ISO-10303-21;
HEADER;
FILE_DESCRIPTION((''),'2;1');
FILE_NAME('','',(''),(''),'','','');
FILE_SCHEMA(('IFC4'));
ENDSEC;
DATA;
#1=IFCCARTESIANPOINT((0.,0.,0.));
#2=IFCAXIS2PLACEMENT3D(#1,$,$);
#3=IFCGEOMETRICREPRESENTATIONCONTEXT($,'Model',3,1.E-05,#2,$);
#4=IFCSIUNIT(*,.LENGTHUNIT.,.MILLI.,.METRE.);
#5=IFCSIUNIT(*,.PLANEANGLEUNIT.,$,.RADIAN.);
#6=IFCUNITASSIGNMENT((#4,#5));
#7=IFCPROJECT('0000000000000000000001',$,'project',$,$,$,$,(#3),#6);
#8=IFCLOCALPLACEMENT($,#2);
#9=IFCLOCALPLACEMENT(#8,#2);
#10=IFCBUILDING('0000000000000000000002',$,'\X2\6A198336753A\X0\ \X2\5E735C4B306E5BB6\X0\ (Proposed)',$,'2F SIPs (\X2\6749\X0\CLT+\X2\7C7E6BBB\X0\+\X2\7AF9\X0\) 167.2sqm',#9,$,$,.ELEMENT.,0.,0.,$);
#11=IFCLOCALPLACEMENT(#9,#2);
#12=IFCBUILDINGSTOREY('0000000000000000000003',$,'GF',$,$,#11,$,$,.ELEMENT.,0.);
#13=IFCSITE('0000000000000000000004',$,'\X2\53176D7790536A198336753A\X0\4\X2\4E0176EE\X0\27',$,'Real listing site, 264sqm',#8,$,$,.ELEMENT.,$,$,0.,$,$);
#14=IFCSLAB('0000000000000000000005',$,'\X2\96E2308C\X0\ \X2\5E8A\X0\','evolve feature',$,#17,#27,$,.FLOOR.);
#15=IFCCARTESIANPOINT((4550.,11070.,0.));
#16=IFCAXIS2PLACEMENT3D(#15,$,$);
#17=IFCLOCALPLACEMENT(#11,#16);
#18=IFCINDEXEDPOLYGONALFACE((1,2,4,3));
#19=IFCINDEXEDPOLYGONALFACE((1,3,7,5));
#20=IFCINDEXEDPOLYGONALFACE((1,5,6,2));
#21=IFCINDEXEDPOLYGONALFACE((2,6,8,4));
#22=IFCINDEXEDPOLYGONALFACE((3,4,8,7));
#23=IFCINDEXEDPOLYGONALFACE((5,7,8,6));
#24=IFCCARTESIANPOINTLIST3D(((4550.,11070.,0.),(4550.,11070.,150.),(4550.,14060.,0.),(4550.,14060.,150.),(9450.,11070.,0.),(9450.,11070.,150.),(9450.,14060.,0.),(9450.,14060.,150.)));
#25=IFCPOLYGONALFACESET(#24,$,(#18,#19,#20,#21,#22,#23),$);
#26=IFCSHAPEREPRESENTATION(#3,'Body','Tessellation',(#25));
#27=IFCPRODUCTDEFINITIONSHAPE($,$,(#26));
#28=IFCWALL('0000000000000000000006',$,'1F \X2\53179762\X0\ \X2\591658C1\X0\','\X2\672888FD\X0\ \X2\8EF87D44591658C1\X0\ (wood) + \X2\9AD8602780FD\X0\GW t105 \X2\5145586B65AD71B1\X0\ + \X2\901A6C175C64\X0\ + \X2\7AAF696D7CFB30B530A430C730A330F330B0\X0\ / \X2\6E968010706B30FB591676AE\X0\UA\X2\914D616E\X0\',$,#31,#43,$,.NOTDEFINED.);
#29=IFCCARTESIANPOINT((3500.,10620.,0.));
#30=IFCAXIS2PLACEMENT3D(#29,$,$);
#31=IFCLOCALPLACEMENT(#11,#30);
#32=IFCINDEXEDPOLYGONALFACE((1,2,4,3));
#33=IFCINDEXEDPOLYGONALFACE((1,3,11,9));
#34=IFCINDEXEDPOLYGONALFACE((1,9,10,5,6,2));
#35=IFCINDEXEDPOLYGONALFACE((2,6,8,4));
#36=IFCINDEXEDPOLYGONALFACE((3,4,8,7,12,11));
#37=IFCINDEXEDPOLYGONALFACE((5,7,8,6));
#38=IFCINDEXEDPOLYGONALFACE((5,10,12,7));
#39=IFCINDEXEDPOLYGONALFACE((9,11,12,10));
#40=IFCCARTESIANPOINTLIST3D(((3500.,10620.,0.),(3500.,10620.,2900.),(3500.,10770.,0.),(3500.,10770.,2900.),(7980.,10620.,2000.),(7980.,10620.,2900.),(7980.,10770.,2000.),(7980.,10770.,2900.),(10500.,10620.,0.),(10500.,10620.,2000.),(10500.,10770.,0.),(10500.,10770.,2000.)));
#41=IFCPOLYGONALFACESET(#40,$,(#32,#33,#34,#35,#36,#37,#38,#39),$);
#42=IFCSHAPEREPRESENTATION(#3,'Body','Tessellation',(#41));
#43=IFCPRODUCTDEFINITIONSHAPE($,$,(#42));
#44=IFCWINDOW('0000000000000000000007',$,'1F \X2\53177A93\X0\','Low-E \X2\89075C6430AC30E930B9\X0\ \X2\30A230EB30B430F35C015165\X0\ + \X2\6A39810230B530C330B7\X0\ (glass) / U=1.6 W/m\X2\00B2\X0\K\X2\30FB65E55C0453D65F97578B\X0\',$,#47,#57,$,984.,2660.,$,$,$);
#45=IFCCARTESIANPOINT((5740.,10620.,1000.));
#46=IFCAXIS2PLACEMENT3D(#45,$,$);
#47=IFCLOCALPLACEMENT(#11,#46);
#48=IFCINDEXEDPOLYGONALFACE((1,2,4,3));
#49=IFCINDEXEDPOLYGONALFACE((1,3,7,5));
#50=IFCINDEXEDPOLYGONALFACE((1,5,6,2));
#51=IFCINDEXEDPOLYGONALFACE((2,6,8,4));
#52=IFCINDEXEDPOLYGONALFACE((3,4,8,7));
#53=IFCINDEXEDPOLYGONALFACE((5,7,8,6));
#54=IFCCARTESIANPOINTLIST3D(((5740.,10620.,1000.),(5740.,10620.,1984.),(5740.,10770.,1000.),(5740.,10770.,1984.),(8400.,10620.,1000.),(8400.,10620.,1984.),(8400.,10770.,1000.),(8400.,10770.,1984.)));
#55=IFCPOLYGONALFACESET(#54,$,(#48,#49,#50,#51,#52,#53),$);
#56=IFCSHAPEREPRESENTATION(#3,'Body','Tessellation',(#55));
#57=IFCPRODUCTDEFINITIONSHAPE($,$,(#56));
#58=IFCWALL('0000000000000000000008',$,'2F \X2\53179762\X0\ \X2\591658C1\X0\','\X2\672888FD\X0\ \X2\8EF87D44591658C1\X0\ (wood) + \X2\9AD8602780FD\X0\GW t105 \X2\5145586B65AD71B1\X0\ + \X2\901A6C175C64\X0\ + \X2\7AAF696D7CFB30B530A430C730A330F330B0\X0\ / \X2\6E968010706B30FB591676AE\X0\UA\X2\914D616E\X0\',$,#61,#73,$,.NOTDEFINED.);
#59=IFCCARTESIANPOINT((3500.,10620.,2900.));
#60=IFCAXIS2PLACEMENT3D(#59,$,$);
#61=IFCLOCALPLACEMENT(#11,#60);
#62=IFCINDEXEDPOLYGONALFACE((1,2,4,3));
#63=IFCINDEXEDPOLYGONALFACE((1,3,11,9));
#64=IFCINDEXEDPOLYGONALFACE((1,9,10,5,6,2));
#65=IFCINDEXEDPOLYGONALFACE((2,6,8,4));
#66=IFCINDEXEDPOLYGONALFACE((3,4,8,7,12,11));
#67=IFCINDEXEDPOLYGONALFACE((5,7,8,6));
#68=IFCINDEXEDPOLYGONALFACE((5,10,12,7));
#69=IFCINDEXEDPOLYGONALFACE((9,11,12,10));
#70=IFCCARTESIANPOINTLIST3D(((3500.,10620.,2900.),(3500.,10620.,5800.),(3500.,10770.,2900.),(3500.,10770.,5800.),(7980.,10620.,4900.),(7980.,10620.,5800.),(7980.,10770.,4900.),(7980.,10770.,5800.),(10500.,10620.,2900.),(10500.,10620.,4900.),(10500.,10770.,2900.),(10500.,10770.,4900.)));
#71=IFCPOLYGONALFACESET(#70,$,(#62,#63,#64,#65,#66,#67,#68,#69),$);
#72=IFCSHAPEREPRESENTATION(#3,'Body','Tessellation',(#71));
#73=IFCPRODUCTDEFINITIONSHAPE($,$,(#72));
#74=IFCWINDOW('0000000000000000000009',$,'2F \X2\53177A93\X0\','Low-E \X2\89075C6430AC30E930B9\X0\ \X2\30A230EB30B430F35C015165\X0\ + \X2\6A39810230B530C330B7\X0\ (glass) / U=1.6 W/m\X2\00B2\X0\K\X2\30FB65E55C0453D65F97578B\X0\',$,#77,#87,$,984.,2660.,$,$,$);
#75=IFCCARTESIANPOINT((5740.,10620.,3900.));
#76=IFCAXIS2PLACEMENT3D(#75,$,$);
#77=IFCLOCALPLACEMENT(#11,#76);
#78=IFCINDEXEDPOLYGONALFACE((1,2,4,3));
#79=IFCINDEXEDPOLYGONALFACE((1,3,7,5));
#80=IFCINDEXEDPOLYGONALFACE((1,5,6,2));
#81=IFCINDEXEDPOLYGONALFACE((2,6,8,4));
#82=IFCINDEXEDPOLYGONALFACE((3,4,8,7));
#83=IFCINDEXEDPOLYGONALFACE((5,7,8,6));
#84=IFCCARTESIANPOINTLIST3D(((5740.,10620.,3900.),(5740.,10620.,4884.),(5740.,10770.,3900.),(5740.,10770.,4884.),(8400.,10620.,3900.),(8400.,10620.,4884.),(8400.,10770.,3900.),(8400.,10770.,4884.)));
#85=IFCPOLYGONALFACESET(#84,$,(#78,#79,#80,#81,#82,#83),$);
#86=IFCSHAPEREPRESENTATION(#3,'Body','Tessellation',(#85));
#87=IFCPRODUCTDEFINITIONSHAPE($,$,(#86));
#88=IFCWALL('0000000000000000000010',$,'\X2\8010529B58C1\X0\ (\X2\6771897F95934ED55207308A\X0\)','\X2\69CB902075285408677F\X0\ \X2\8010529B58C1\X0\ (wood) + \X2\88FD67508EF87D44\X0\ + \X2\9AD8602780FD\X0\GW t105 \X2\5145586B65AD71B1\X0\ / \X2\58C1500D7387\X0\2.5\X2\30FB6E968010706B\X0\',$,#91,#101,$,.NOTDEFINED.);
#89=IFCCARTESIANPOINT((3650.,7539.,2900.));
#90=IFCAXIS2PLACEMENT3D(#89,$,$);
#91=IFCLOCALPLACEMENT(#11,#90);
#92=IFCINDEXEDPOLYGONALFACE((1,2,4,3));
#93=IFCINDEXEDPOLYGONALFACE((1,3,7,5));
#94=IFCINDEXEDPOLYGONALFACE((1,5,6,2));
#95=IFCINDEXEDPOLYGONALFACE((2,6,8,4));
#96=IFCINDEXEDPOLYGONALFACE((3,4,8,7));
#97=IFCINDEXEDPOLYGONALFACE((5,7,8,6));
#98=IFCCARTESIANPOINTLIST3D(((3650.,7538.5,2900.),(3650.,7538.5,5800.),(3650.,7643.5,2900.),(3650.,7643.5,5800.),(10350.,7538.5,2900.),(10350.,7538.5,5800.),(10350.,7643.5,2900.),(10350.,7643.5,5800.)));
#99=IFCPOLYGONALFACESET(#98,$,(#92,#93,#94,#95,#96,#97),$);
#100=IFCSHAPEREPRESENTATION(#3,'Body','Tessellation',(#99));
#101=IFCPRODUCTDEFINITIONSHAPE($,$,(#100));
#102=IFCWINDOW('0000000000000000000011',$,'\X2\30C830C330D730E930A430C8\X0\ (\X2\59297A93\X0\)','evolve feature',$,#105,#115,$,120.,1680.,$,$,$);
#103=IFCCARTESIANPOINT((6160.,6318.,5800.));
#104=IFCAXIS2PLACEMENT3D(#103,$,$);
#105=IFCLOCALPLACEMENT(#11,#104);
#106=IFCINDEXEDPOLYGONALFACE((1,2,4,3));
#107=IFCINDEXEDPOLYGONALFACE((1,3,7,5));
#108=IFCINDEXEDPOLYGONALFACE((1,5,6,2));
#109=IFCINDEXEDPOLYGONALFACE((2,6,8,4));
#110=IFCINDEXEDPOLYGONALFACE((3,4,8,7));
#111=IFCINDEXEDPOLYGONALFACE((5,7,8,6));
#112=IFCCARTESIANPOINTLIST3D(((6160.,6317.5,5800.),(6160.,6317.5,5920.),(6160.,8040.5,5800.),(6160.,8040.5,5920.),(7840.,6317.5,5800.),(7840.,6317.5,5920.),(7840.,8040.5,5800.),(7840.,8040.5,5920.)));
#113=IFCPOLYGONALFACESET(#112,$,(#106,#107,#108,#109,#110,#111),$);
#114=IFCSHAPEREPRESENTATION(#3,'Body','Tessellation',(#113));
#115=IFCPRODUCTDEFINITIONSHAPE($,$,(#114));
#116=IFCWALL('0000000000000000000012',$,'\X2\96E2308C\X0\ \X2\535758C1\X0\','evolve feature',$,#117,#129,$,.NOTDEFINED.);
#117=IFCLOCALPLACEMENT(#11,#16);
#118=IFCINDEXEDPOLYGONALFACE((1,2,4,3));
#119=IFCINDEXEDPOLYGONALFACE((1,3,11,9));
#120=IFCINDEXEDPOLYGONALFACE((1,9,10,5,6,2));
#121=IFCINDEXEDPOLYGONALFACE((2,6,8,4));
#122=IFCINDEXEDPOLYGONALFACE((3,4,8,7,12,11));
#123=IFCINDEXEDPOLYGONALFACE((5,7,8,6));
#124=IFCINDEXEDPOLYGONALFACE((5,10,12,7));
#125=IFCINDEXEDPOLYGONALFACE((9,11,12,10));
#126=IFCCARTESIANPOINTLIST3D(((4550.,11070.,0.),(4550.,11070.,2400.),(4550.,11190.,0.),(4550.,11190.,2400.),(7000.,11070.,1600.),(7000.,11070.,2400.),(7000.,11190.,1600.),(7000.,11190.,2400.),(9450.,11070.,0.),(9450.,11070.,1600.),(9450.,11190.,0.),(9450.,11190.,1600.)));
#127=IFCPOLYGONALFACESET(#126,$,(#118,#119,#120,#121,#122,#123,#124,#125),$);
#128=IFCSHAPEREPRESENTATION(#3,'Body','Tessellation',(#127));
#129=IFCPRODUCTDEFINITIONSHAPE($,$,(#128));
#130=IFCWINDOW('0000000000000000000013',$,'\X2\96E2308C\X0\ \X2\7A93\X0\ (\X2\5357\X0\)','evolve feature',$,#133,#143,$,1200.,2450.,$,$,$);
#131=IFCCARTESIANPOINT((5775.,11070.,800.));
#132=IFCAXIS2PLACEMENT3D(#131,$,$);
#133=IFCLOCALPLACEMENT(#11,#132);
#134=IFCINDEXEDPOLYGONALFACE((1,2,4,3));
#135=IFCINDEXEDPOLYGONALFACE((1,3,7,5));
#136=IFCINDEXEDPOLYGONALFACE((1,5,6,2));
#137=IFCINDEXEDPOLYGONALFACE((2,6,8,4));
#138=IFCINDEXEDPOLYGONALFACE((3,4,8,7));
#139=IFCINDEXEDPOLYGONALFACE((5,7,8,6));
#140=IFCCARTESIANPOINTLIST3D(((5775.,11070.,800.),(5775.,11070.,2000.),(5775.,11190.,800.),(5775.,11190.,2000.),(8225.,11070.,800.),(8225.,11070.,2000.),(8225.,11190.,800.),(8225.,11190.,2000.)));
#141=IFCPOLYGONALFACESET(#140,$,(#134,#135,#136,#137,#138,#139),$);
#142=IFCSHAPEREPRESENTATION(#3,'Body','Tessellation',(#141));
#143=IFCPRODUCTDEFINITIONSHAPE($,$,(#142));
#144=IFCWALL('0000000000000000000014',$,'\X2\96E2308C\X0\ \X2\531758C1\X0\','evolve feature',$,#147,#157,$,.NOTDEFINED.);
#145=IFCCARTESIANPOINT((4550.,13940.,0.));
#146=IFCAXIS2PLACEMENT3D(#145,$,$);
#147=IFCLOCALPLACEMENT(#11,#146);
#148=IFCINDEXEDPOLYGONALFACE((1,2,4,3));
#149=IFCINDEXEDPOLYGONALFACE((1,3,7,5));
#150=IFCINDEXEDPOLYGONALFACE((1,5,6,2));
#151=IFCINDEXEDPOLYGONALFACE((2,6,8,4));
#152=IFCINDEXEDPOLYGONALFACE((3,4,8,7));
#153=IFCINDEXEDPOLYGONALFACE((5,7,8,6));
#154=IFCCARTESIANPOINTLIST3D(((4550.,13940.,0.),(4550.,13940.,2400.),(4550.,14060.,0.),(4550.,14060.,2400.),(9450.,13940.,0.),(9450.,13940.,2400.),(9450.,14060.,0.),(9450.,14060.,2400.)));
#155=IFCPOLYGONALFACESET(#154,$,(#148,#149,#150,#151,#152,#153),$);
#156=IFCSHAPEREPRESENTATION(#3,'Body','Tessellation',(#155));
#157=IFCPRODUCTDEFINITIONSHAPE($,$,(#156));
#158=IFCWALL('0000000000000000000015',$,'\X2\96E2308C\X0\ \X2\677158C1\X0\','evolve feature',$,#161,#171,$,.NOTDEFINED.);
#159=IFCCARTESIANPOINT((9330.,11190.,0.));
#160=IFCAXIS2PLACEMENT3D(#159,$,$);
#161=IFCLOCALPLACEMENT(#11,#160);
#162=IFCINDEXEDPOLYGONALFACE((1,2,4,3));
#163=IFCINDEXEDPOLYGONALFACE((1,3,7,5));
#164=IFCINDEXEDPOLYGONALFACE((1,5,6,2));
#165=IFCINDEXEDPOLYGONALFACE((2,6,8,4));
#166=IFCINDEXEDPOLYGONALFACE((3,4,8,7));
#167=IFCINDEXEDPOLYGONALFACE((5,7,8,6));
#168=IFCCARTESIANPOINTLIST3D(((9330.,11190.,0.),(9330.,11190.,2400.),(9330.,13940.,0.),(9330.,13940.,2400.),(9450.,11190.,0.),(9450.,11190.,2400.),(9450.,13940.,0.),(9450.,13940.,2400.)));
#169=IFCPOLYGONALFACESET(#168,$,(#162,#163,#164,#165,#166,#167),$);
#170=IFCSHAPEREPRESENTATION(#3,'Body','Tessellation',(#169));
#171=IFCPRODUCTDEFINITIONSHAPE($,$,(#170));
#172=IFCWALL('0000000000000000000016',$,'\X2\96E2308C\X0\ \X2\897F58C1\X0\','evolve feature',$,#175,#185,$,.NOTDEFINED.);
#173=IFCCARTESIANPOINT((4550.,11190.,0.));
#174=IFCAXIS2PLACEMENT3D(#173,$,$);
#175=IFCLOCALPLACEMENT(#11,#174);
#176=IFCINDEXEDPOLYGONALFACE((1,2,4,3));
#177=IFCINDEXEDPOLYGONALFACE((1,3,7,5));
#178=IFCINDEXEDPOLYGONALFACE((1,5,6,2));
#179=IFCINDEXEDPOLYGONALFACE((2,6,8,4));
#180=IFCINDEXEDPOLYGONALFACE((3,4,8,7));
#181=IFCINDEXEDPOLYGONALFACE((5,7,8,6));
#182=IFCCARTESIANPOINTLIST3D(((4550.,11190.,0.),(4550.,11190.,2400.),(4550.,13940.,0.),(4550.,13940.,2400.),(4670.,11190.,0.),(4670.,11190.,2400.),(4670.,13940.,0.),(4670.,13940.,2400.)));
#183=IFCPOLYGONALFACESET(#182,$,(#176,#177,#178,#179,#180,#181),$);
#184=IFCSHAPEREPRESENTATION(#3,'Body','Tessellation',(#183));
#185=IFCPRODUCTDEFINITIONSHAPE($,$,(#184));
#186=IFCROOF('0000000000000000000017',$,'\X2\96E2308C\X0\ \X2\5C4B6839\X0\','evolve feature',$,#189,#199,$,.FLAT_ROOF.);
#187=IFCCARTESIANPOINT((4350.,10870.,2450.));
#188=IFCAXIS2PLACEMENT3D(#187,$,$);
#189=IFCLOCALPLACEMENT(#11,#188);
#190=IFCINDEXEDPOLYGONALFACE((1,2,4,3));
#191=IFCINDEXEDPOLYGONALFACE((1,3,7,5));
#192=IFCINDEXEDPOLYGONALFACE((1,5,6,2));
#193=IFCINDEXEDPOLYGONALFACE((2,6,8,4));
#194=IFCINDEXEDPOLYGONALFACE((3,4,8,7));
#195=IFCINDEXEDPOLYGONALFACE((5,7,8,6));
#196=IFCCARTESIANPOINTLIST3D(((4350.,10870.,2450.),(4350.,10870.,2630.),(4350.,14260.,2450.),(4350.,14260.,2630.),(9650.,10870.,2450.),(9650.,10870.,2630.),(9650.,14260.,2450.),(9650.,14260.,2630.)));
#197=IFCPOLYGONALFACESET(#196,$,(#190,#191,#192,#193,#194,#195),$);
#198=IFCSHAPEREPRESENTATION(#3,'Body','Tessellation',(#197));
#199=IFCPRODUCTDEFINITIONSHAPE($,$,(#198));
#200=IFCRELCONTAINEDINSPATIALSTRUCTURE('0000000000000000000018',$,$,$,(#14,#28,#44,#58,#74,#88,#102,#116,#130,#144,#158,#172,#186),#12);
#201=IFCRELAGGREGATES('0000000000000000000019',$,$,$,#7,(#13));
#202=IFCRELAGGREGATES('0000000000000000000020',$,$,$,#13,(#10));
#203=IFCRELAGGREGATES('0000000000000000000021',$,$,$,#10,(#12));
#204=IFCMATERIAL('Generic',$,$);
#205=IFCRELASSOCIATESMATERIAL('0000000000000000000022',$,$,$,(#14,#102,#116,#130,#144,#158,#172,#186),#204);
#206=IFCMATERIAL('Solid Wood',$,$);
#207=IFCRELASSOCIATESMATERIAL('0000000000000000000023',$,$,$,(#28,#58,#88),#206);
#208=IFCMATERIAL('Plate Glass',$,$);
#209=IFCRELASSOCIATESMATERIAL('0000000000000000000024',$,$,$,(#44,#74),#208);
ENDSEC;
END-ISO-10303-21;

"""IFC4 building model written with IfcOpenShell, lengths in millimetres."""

from ifc_helpers import new_model, si_unit, frame, frame_2d, origin, place, context, project, spatial, rectangle, extrude, material, element, fill, save


model = new_model("IFC4")

# Units and contexts
model_context = context("Model", 3, precision=1e-05, world=origin())
ifc_project = project(units=[si_unit("LENGTHUNIT", "METRE", prefix="MILLI"), si_unit("PLANEANGLEUNIT", "RADIAN")], contexts=[model_context])

# Site, building, storey
site_placement = place(None, origin())
site = spatial("IfcSite", under=ifc_project, at=site_placement, Name="北海道標茶町4丁目27", ObjectType="Real listing site, 264sqm", CompositionType="ELEMENT", RefElevation=0.0)
building_placement = place(site_placement, origin())
building = spatial("IfcBuilding", under=site, at=building_placement, Name="標茶町 平屋の家 (Proposed)", ObjectType="2F SIPs (杉CLT+籾殻+竹) 167.2sqm", CompositionType="ELEMENT", ElevationOfRefHeight=0.0, ElevationOfTerrain=0.0)
storey_placement = place(building_placement, origin())
storey = spatial("IfcBuildingStorey", under=building, at=storey_placement, Name="GF", CompositionType="ELEMENT", Elevation=0.0)

# Slab
ifc_material_1 = material(Name="Generic")
slab_placement = place(storey_placement, frame((4550.0, 11070.0, 0.0)))
element("IfcSlab", 1, at=slab_placement, inside=storey, material=ifc_material_1, Name="離れ 床", Description="evolve feature", PredefinedType="FLOOR", context=model_context, shape_type="SweptSolid", body=[
    extrude(rectangle(XDim=4900.0, YDim=2990.0, at=frame_2d((2450.0, 1495.0))), frame((4550.0, 11070.0, 0.0)), (0.0, 0.0, 1.0), 150.0),
])

# Wall, opening, window
ifc_material_2 = material(Name="Solid Wood")
wall_1_placement = place(storey_placement, frame((3500.0, 10620.0, 0.0)))
wall_1 = element("IfcWall", 2, at=wall_1_placement, inside=storey, material=ifc_material_2, Name="1F 北面 外壁", Description="木製 軸組外壁 (wood) + 高性能GW t105 充填断熱 + 通気層 + 窯業系サイディング / 準耐火・外皮UA配慮", PredefinedType="NOTDEFINED", context=model_context, shape_type="SweptSolid", body=[
    extrude(rectangle(XDim=7000.0, YDim=150.0, at=frame_2d((3500.0, 75.0))), frame((3500.0, 10620.0, 0.0)), (0.0, 0.0, 1.0), 2900.0),
])
opening_1_placement = place(storey_placement, frame((5740.0, 10620.0, 1000.0)))
opening_1 = element("IfcOpeningElement", 3, at=opening_1_placement, cuts=wall_1, PredefinedType="NOTDEFINED", context=model_context, shape_type="SweptSolid", body=[
    extrude(rectangle(XDim=2660.0, YDim=150.0, at=frame_2d((1330.0, 75.0))), frame((5740.0, 10620.0, 1000.0)), (0.0, 0.0, 1.0), 984.0),
])
ifc_material_3 = material(Name="Plate Glass")
window_1_placement = place(storey_placement, frame((5740.0, 10620.0, 1000.0)))
window_1 = element("IfcWindow", 4, at=window_1_placement, inside=storey, material=ifc_material_3, Name="1F 北窓", Description="Low-E 複層ガラス アルゴン封入 + 樹脂サッシ (glass) / U=1.6 W/m²K・日射取得型", OverallHeight=984.0, OverallWidth=2660.0, context=model_context, shape_type="SweptSolid", body=[
    extrude(rectangle(XDim=2660.0, YDim=150.0, at=frame_2d((1330.0, 75.0))), frame((5740.0, 10620.0, 1000.0)), (0.0, 0.0, 1.0), 984.0),
])
fill(opening_1, window_1)

# Wall, opening, window
wall_2_placement = place(storey_placement, frame((3500.0, 10620.0, 2900.0)))
wall_2 = element("IfcWall", 5, at=wall_2_placement, inside=storey, material=ifc_material_2, Name="2F 北面 外壁", Description="木製 軸組外壁 (wood) + 高性能GW t105 充填断熱 + 通気層 + 窯業系サイディング / 準耐火・外皮UA配慮", PredefinedType="NOTDEFINED", context=model_context, shape_type="SweptSolid", body=[
    extrude(rectangle(XDim=7000.0, YDim=150.0, at=frame_2d((3500.0, 75.0))), frame((3500.0, 10620.0, 2900.0)), (0.0, 0.0, 1.0), 2900.0),
])
opening_2_placement = place(storey_placement, frame((5740.0, 10620.0, 3900.0)))
opening_2 = element("IfcOpeningElement", 6, at=opening_2_placement, cuts=wall_2, PredefinedType="NOTDEFINED", context=model_context, shape_type="SweptSolid", body=[
    extrude(rectangle(XDim=2660.0, YDim=150.0, at=frame_2d((1330.0, 75.0))), frame((5740.0, 10620.0, 3900.0)), (0.0, 0.0, 1.0), 984.0),
])
window_2_placement = place(storey_placement, frame((5740.0, 10620.0, 3900.0)))
window_2 = element("IfcWindow", 7, at=window_2_placement, inside=storey, material=ifc_material_3, Name="2F 北窓", Description="Low-E 複層ガラス アルゴン封入 + 樹脂サッシ (glass) / U=1.6 W/m²K・日射取得型", OverallHeight=984.0, OverallWidth=2660.0, context=model_context, shape_type="SweptSolid", body=[
    extrude(rectangle(XDim=2660.0, YDim=150.0, at=frame_2d((1330.0, 75.0))), frame((5740.0, 10620.0, 3900.0)), (0.0, 0.0, 1.0), 984.0),
])
fill(opening_2, window_2)

# Wall
wall_3_placement = place(storey_placement, frame((3650.0, 7539.0, 2900.0)))
element("IfcWall", 8, at=wall_3_placement, inside=storey, material=ifc_material_2, Name="耐力壁 (東西間仕切り)", Description="構造用合板 耐力壁 (wood) + 製材軸組 + 高性能GW t105 充填断熱 / 壁倍率2.5・準耐火", PredefinedType="NOTDEFINED", context=model_context, shape_type="SweptSolid", body=[
    extrude(rectangle(XDim=6700.0, YDim=105.0, at=frame_2d((3350.0, 52.0))), frame((3650.0, 7539.0, 2900.0)), (0.0, 0.0, 1.0), 2900.0),
])

# Window
window_3_placement = place(storey_placement, frame((6160.0, 6318.0, 5800.0)))
element("IfcWindow", 9, at=window_3_placement, inside=storey, material=ifc_material_1, Name="トップライト (天窓)", Description="evolve feature", OverallHeight=120.0, OverallWidth=1680.0, context=model_context, shape_type="SweptSolid", body=[
    extrude(rectangle(XDim=1680.0, YDim=1723.0, at=frame_2d((840.0, 861.0))), frame((6160.0, 6318.0, 5800.0)), (0.0, 0.0, 1.0), 120.0),
])

# Wall, opening, window
wall_4_placement = place(storey_placement, frame((4550.0, 11070.0, 0.0)))
wall_4 = element("IfcWall", 10, at=wall_4_placement, inside=storey, material=ifc_material_1, Name="離れ 南壁", Description="evolve feature", PredefinedType="NOTDEFINED", context=model_context, shape_type="SweptSolid", body=[
    extrude(rectangle(XDim=4900.0, YDim=120.0, at=frame_2d((2450.0, 60.0))), frame((4550.0, 11070.0, 0.0)), (0.0, 0.0, 1.0), 2400.0),
])
opening_3_placement = place(storey_placement, frame((5775.0, 11070.0, 800.0)))
opening_3 = element("IfcOpeningElement", 11, at=opening_3_placement, cuts=wall_4, PredefinedType="NOTDEFINED", context=model_context, shape_type="SweptSolid", body=[
    extrude(rectangle(XDim=2450.0, YDim=120.0, at=frame_2d((1225.0, 60.0))), frame((5775.0, 11070.0, 800.0)), (0.0, 0.0, 1.0), 1200.0),
])
window_4_placement = place(storey_placement, frame((5775.0, 11070.0, 800.0)))
window_4 = element("IfcWindow", 12, at=window_4_placement, inside=storey, material=ifc_material_1, Name="離れ 窓 (南)", Description="evolve feature", OverallHeight=1200.0, OverallWidth=2450.0, context=model_context, shape_type="SweptSolid", body=[
    extrude(rectangle(XDim=2450.0, YDim=120.0, at=frame_2d((1225.0, 60.0))), frame((5775.0, 11070.0, 800.0)), (0.0, 0.0, 1.0), 1200.0),
])
fill(opening_3, window_4)

# Walls
wall_5_placement = place(storey_placement, frame((4550.0, 13940.0, 0.0)))
element("IfcWall", 13, at=wall_5_placement, inside=storey, material=ifc_material_1, Name="離れ 北壁", Description="evolve feature", PredefinedType="NOTDEFINED", context=model_context, shape_type="SweptSolid", body=[
    extrude(rectangle(XDim=4900.0, YDim=120.0, at=frame_2d((2450.0, 60.0))), frame((4550.0, 13940.0, 0.0)), (0.0, 0.0, 1.0), 2400.0),
])
wall_6_placement = place(storey_placement, frame((9330.0, 11190.0, 0.0)))
element("IfcWall", 14, at=wall_6_placement, inside=storey, material=ifc_material_1, Name="離れ 東壁", Description="evolve feature", PredefinedType="NOTDEFINED", context=model_context, shape_type="SweptSolid", body=[
    extrude(rectangle(XDim=120.0, YDim=2750.0, at=frame_2d((60.0, 1375.0))), frame((9330.0, 11190.0, 0.0)), (0.0, 0.0, 1.0), 2400.0),
])
wall_7_placement = place(storey_placement, frame((4550.0, 11190.0, 0.0)))
element("IfcWall", 15, at=wall_7_placement, inside=storey, material=ifc_material_1, Name="離れ 西壁", Description="evolve feature", PredefinedType="NOTDEFINED", context=model_context, shape_type="SweptSolid", body=[
    extrude(rectangle(XDim=120.0, YDim=2750.0, at=frame_2d((60.0, 1375.0))), frame((4550.0, 11190.0, 0.0)), (0.0, 0.0, 1.0), 2400.0),
])

# Roof
roof_placement = place(storey_placement, frame((4350.0, 10870.0, 2450.0)))
element("IfcRoof", 16, at=roof_placement, inside=storey, material=ifc_material_1, Name="離れ 屋根", Description="evolve feature", PredefinedType="FLAT_ROOF", context=model_context, shape_type="SweptSolid", body=[
    extrude(rectangle(XDim=5300.0, YDim=3390.0, at=frame_2d((2650.0, 1695.0))), frame((4350.0, 10870.0, 2450.0)), (0.0, 0.0, 1.0), 180.0),
])

save(model, "model.ifc")
